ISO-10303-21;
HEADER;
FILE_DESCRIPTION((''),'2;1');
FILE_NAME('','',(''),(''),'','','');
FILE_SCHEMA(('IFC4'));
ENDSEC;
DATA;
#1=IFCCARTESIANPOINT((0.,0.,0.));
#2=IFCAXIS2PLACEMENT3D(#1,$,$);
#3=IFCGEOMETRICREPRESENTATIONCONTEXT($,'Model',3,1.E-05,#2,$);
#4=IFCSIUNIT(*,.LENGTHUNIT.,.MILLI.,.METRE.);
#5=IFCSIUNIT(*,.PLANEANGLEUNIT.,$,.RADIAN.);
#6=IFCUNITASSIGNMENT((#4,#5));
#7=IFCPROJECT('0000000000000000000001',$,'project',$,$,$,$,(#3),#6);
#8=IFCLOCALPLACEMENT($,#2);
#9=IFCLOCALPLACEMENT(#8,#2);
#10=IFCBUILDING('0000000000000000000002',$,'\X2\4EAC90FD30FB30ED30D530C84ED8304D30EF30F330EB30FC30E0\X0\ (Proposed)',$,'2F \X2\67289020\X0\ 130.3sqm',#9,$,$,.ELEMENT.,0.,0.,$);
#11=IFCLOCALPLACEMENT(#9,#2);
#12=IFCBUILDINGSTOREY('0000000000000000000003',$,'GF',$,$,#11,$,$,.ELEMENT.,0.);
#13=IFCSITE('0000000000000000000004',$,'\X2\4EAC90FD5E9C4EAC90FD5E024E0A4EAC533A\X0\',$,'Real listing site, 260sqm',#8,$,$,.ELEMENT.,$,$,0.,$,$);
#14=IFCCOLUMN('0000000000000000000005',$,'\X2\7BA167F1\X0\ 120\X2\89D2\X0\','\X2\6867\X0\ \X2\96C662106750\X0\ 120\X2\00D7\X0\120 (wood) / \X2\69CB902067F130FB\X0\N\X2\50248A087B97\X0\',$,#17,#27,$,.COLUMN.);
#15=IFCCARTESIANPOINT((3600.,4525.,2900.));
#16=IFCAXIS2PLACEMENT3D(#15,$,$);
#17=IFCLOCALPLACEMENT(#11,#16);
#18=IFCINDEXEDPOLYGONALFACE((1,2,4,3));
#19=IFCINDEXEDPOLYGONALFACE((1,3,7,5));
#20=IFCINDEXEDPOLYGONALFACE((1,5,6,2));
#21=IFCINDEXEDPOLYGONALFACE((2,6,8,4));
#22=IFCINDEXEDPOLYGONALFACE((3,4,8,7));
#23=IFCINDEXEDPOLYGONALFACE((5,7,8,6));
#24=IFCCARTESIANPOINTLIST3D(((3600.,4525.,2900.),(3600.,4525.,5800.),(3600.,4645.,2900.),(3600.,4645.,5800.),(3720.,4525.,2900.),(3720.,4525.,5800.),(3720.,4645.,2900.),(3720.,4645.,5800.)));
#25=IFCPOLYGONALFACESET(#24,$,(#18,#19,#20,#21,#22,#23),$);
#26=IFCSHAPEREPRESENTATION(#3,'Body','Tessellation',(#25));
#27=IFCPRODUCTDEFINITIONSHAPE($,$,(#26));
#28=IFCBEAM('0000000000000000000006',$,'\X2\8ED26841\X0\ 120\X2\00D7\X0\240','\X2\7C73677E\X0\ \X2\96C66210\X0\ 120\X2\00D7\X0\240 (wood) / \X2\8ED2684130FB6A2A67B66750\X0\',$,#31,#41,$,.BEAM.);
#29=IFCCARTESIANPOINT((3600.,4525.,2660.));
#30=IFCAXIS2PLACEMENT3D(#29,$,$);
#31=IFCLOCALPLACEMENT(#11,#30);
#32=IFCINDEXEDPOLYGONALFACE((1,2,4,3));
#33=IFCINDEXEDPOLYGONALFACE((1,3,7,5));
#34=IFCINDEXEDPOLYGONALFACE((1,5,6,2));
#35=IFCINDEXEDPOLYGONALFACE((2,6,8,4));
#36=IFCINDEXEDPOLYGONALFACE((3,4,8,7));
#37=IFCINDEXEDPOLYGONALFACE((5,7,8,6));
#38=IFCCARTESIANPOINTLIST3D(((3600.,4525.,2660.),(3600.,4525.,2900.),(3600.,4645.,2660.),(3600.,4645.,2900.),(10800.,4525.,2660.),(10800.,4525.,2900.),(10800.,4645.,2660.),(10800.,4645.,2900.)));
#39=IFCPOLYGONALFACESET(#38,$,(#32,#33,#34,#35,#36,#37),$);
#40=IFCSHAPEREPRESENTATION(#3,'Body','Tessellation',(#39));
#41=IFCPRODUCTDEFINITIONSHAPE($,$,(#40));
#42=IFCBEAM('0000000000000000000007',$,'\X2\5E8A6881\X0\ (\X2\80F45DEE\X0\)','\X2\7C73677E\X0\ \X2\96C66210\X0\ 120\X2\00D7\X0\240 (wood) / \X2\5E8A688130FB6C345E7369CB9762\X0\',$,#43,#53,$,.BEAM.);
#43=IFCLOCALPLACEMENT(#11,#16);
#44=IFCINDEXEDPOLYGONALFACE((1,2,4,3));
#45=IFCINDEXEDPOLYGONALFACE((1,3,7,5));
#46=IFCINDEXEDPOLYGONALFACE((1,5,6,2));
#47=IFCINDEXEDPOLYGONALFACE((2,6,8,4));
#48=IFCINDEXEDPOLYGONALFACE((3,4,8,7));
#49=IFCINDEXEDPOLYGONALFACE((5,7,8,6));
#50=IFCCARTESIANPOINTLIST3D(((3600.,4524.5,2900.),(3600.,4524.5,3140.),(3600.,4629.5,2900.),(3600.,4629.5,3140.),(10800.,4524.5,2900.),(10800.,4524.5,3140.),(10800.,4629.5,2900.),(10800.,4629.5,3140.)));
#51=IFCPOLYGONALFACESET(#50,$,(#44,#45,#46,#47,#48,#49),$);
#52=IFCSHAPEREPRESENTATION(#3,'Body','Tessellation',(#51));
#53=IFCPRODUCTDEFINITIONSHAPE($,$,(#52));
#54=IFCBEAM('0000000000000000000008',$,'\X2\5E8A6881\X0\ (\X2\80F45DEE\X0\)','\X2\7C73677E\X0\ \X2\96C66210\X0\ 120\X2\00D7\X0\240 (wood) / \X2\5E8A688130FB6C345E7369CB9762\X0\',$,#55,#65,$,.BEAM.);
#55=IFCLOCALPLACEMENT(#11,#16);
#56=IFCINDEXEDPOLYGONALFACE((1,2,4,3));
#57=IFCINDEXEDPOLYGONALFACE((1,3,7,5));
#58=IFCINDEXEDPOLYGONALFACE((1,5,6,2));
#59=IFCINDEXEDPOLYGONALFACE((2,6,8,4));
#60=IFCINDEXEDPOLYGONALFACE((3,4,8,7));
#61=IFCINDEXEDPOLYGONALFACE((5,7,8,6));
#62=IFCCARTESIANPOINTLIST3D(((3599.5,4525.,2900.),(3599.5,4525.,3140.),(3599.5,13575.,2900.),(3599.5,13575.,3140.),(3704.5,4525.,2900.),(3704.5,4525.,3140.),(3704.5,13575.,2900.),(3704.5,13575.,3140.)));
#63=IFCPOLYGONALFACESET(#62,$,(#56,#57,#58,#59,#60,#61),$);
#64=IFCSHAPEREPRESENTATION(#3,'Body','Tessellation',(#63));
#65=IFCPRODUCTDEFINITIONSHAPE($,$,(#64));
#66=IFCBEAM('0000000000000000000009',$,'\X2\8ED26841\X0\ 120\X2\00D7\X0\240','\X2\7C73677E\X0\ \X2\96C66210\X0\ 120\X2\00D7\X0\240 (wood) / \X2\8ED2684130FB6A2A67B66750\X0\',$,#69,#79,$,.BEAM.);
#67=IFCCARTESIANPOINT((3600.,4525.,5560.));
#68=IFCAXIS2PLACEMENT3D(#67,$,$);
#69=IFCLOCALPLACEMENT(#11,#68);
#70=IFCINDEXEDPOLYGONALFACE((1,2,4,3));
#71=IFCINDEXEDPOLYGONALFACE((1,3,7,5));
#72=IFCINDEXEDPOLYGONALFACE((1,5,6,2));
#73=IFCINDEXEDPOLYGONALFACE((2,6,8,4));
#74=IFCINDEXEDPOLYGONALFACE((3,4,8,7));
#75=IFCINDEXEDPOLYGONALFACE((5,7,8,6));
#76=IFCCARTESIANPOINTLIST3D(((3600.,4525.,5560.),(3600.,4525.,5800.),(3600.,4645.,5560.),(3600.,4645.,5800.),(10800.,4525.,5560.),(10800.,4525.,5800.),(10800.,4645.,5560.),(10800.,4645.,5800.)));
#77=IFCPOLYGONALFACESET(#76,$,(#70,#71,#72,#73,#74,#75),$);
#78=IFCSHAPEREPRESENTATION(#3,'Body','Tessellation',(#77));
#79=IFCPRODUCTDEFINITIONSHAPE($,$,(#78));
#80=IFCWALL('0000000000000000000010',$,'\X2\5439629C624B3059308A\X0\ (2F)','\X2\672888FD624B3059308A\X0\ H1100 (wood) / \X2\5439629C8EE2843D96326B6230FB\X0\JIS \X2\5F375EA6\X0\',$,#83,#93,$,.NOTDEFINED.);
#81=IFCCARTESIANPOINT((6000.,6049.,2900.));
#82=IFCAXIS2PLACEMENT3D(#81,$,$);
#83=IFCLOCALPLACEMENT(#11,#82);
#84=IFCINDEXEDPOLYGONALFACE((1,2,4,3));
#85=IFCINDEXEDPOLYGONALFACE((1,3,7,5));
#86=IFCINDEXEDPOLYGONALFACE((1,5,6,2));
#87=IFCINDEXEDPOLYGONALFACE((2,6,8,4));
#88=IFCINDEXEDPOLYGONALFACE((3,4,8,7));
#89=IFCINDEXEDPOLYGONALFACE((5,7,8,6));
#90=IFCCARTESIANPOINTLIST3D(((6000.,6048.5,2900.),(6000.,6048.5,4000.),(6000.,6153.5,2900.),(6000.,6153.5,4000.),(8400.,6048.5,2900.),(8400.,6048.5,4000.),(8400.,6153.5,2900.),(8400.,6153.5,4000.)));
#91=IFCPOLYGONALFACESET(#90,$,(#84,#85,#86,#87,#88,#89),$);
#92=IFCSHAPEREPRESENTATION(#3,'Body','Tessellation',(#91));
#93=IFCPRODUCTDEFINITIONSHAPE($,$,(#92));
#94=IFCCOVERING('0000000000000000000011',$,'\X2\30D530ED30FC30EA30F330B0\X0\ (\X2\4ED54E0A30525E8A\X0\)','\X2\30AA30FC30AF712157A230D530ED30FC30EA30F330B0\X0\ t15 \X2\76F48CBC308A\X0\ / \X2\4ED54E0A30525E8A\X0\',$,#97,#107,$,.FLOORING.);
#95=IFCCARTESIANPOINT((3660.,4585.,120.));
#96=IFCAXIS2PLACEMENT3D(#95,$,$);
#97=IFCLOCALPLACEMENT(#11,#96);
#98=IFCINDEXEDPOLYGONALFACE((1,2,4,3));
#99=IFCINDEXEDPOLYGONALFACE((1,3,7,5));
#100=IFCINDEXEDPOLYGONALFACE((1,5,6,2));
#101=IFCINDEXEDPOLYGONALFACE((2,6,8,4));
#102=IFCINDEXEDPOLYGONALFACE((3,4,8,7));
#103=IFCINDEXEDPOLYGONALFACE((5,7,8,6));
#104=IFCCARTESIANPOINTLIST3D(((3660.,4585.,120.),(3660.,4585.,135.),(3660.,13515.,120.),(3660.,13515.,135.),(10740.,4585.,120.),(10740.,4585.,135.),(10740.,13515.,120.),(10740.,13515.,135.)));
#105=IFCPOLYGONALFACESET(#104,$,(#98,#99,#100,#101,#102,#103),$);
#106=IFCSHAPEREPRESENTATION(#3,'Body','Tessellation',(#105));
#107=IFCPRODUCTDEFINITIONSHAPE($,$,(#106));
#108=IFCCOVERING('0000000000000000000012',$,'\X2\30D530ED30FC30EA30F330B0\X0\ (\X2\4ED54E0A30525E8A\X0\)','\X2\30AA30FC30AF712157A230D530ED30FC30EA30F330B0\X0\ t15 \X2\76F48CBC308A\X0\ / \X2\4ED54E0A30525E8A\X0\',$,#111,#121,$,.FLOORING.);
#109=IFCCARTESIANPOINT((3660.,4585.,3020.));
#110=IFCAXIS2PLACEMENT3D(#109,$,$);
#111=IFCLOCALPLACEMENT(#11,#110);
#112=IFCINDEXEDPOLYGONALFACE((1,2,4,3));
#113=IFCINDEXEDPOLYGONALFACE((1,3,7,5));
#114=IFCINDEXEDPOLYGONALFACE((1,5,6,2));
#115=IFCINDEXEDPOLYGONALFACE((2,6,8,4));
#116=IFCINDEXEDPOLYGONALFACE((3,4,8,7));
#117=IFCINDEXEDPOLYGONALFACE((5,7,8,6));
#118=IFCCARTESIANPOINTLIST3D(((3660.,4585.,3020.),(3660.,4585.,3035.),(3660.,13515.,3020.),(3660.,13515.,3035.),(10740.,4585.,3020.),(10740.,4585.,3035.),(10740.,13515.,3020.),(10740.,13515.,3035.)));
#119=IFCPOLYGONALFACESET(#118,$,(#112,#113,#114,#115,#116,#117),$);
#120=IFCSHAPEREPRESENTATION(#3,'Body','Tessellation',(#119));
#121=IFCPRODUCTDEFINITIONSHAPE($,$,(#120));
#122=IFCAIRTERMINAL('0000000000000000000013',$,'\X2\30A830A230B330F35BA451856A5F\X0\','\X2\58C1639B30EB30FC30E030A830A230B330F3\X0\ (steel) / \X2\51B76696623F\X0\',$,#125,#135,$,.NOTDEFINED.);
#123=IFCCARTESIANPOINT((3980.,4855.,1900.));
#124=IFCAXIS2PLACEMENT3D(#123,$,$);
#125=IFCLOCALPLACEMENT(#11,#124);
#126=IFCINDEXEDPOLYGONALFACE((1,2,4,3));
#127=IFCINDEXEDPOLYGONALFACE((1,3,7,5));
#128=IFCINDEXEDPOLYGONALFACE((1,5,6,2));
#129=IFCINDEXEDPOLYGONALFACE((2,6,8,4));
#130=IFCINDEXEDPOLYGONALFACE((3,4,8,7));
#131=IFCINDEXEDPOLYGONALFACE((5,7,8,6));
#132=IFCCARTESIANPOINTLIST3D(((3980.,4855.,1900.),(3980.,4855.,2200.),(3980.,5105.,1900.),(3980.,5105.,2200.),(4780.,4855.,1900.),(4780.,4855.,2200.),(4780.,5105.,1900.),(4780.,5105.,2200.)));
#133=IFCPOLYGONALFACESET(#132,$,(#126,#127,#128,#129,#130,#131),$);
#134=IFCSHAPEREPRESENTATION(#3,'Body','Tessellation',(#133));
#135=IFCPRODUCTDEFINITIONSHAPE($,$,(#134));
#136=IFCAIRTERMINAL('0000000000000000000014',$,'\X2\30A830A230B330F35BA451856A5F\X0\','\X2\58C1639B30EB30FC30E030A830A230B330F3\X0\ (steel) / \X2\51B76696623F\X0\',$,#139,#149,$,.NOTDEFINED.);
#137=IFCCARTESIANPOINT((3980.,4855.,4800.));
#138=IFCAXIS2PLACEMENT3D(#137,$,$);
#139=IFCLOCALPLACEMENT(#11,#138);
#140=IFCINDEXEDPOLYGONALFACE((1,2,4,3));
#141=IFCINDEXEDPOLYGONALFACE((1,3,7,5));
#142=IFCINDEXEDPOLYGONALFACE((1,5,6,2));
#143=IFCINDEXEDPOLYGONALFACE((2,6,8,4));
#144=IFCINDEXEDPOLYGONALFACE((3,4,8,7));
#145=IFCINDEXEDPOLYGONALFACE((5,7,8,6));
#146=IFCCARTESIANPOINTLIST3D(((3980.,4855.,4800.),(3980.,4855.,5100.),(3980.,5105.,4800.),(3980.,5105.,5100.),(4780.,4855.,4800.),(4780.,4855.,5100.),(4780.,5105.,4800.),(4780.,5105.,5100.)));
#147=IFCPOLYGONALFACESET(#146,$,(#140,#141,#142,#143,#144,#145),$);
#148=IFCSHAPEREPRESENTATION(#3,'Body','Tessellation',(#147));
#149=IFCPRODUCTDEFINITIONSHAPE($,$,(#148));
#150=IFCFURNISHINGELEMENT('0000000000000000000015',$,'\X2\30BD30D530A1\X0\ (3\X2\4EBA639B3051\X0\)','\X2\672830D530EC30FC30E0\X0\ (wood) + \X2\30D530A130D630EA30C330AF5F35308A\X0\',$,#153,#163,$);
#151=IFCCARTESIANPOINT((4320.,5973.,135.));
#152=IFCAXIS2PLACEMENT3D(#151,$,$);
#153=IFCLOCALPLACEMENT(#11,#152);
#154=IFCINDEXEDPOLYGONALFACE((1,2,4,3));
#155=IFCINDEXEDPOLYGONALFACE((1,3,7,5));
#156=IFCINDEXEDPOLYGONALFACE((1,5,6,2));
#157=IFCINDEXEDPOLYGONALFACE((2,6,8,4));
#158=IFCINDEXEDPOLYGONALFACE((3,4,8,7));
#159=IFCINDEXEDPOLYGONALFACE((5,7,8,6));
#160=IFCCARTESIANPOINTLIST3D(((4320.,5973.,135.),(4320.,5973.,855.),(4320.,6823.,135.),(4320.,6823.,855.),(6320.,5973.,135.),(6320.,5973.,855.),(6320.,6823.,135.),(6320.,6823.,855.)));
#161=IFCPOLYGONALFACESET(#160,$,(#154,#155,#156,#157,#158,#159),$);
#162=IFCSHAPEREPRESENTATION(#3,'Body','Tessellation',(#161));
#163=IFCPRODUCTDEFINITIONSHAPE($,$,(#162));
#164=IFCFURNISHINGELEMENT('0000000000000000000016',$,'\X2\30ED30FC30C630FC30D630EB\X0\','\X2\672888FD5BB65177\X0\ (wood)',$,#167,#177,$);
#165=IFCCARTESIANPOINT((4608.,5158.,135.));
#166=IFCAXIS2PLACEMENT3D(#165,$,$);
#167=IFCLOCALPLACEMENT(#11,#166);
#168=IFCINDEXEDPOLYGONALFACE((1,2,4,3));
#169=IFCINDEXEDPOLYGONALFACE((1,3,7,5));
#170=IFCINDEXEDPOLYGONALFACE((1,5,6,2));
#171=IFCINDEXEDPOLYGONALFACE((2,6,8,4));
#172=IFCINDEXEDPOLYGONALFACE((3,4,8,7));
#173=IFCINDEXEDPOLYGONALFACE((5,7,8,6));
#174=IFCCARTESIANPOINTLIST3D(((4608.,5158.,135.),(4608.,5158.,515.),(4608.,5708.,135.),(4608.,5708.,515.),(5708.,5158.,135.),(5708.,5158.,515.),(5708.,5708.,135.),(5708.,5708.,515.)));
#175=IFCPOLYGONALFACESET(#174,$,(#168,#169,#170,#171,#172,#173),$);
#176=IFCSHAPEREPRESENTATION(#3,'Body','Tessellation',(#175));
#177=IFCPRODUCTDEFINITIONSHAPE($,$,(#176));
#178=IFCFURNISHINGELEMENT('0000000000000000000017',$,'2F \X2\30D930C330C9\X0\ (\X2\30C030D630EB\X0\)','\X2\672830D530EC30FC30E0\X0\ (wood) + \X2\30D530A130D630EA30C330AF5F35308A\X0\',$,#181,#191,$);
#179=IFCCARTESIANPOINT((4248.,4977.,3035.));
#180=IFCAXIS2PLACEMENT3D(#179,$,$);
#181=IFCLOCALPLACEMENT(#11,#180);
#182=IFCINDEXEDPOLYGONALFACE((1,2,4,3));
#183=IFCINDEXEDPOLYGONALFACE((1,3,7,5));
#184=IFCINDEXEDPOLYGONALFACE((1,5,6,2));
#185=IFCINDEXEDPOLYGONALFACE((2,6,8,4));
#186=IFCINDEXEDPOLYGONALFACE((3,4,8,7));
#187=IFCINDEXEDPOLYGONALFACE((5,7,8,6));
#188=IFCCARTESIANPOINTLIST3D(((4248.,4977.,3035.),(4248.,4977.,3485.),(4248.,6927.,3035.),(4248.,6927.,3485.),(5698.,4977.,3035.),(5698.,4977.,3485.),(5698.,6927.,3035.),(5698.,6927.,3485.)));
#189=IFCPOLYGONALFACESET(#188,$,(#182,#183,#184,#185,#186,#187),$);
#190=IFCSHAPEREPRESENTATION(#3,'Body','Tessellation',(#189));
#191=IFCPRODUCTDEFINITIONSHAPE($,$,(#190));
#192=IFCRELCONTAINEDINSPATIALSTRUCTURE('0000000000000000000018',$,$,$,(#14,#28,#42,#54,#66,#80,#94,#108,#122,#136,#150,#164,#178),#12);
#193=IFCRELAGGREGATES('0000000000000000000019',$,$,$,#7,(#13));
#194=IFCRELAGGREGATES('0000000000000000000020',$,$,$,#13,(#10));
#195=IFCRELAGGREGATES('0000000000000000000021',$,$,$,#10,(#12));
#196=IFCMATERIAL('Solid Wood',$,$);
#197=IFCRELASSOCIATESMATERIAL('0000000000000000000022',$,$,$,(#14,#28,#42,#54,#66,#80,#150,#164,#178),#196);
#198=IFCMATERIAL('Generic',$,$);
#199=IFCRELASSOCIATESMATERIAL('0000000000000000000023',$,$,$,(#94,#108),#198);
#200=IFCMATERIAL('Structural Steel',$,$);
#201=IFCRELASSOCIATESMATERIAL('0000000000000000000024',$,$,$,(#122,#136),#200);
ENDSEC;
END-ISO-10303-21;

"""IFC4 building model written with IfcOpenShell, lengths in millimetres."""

from ifc_helpers import new_model, si_unit, frame, frame_2d, origin, place, context, project, spatial, rectangle, extrude, material, element, save


model = new_model("IFC4")

# Units and contexts
model_context = context("Model", 3, precision=1e-05, world=origin())
ifc_project = project(units=[si_unit("LENGTHUNIT", "METRE", prefix="MILLI"), si_unit("PLANEANGLEUNIT", "RADIAN")], contexts=[model_context])

# Site, building, storey
site_placement = place(None, origin())
site = spatial("IfcSite", under=ifc_project, at=site_placement, Name="京都府京都市上京区", ObjectType="Real listing site, 260sqm", CompositionType="ELEMENT", RefElevation=0.0)
building_placement = place(site_placement, origin())
building = spatial("IfcBuilding", under=site, at=building_placement, Name="京都・ロフト付きワンルーム (Proposed)", ObjectType="2F 木造 130.3sqm", CompositionType="ELEMENT", ElevationOfRefHeight=0.0, ElevationOfTerrain=0.0)
storey_placement = place(building_placement, origin())
storey = spatial("IfcBuildingStorey", under=building, at=storey_placement, Name="GF", CompositionType="ELEMENT", Elevation=0.0)

# Column
ifc_material_1 = material(Name="Solid Wood")
column_1_placement = place(storey_placement, frame((3600.0, 4525.0, 2900.0)))
element("IfcColumn", 1, at=column_1_placement, inside=storey, material=ifc_material_1, Name="管柱 120角", Description="桧 集成材 120×120 (wood) / 構造柱・N値計算", PredefinedType="COLUMN", context=model_context, shape_type="SweptSolid", body=[
    extrude(rectangle(XDim=120.0, YDim=120.0, at=frame_2d((60.0, 60.0))), frame((3600.0, 4525.0, 2900.0)), (0.0, 0.0, 1.0), 2900.0),
])

# Beams
beam_1_placement = place(storey_placement, frame((3600.0, 4525.0, 2660.0)))
element("IfcBeam", 2, at=beam_1_placement, inside=storey, material=ifc_material_1, Name="軒桁 120×240", Description="米松 集成 120×240 (wood) / 軒桁・横架材", PredefinedType="BEAM", context=model_context, shape_type="SweptSolid", body=[
    extrude(rectangle(XDim=7200.0, YDim=120.0, at=frame_2d((3600.0, 60.0))), frame((3600.0, 4525.0, 2660.0)), (0.0, 0.0, 1.0), 240.0),
])
beam_2_placement = place(storey_placement, frame((3600.0, 4525.0, 2900.0)))
element("IfcBeam", 3, at=beam_2_placement, inside=storey, material=ifc_material_1, Name="床梁 (胴差)", Description="米松 集成 120×240 (wood) / 床梁・水平構面", PredefinedType="BEAM", context=model_context, shape_type="SweptSolid", body=[
    extrude(rectangle(XDim=7200.0, YDim=105.0, at=frame_2d((3600.0, 52.0))), frame((3600.0, 4525.0, 2900.0)), (0.0, 0.0, 1.0), 240.0),
])
beam_3_placement = place(storey_placement, frame((3600.0, 4525.0, 2900.0)))
element("IfcBeam", 4, at=beam_3_placement, inside=storey, material=ifc_material_1, Name="床梁 (胴差)", Description="米松 集成 120×240 (wood) / 床梁・水平構面", PredefinedType="BEAM", context=model_context, shape_type="SweptSolid", body=[
    extrude(rectangle(XDim=105.0, YDim=9050.0, at=frame_2d((52.0, 4525.0))), frame((3600.0, 4525.0, 2900.0)), (0.0, 0.0, 1.0), 240.0),
])
beam_4_placement = place(storey_placement, frame((3600.0, 4525.0, 5560.0)))
element("IfcBeam", 5, at=beam_4_placement, inside=storey, material=ifc_material_1, Name="軒桁 120×240", Description="米松 集成 120×240 (wood) / 軒桁・横架材", PredefinedType="BEAM", context=model_context, shape_type="SweptSolid", body=[
    extrude(rectangle(XDim=7200.0, YDim=120.0, at=frame_2d((3600.0, 60.0))), frame((3600.0, 4525.0, 5560.0)), (0.0, 0.0, 1.0), 240.0),
])

# Wall
wall_placement = place(storey_placement, frame((6000.0, 6049.0, 2900.0)))
element("IfcWall", 6, at=wall_placement, inside=storey, material=ifc_material_1, Name="吹抜手すり (2F)", Description="木製手すり H1100 (wood) / 吹抜転落防止・JIS 強度", PredefinedType="NOTDEFINED", context=model_context, shape_type="SweptSolid", body=[
    extrude(rectangle(XDim=2400.0, YDim=105.0, at=frame_2d((1200.0, 52.0))), frame((6000.0, 6049.0, 2900.0)), (0.0, 0.0, 1.0), 1100.0),
])

# Coverings
ifc_material_2 = material(Name="Generic")
covering_1_placement = place(storey_placement, frame((3660.0, 4585.0, 120.0)))
element("IfcCovering", 7, at=covering_1_placement, inside=storey, material=ifc_material_2, Name="フローリング (仕上げ床)", Description="オーク無垢フローリング t15 直貼り / 仕上げ床", PredefinedType="FLOORING", context=model_context, shape_type="SweptSolid", body=[
    extrude(rectangle(XDim=7080.0, YDim=8930.0, at=frame_2d((3540.0, 4465.0))), frame((3660.0, 4585.0, 120.0)), (0.0, 0.0, 1.0), 15.0),
])
covering_2_placement = place(storey_placement, frame((3660.0, 4585.0, 3020.0)))
element("IfcCovering", 8, at=covering_2_placement, inside=storey, material=ifc_material_2, Name="フローリング (仕上げ床)", Description="オーク無垢フローリング t15 直貼り / 仕上げ床", PredefinedType="FLOORING", context=model_context, shape_type="SweptSolid", body=[
    extrude(rectangle(XDim=7080.0, YDim=8930.0, at=frame_2d((3540.0, 4465.0))), frame((3660.0, 4585.0, 3020.0)), (0.0, 0.0, 1.0), 15.0),
])

# Air terminals
ifc_material_3 = material(Name="Structural Steel")
air_terminal_1_placement = place(storey_placement, frame((3980.0, 4855.0, 1900.0)))
element("IfcAirTerminal", 9, at=air_terminal_1_placement, inside=storey, material=ifc_material_3, Name="エアコン室内機", Description="壁掛ルームエアコン (steel) / 冷暖房", PredefinedType="NOTDEFINED", context=model_context, shape_type="SweptSolid", body=[
    extrude(rectangle(XDim=800.0, YDim=250.0, at=frame_2d((400.0, 125.0))), frame((3980.0, 4855.0, 1900.0)), (0.0, 0.0, 1.0), 300.0),
])
air_terminal_2_placement = place(storey_placement, frame((3980.0, 4855.0, 4800.0)))
element("IfcAirTerminal", 10, at=air_terminal_2_placement, inside=storey, material=ifc_material_3, Name="エアコン室内機", Description="壁掛ルームエアコン (steel) / 冷暖房", PredefinedType="NOTDEFINED", context=model_context, shape_type="SweptSolid", body=[
    extrude(rectangle(XDim=800.0, YDim=250.0, at=frame_2d((400.0, 125.0))), frame((3980.0, 4855.0, 4800.0)), (0.0, 0.0, 1.0), 300.0),
])

# Furnishing elements
furnishing_1_placement = place(storey_placement, frame((4320.0, 5973.0, 135.0)))
element("IfcFurnishingElement", 11, at=furnishing_1_placement, inside=storey, material=ifc_material_1, Name="ソファ (3人掛け)", Description="木フレーム (wood) + ファブリック張り", context=model_context, shape_type="SweptSolid", body=[
    extrude(rectangle(XDim=2000.0, YDim=850.0, at=frame_2d((1000.0, 425.0))), frame((4320.0, 5973.0, 135.0)), (0.0, 0.0, 1.0), 720.0),
])
furnishing_2_placement = place(storey_placement, frame((4608.0, 5158.0, 135.0)))
element("IfcFurnishingElement", 12, at=furnishing_2_placement, inside=storey, material=ifc_material_1, Name="ローテーブル", Description="木製家具 (wood)", context=model_context, shape_type="SweptSolid", body=[
    extrude(rectangle(XDim=1100.0, YDim=550.0, at=frame_2d((550.0, 275.0))), frame((4608.0, 5158.0, 135.0)), (0.0, 0.0, 1.0), 380.0),
])
furnishing_3_placement = place(storey_placement, frame((4248.0, 4977.0, 3035.0)))
element("IfcFurnishingElement", 13, at=furnishing_3_placement, inside=storey, material=ifc_material_1, Name="2F ベッド (ダブル)", Description="木フレーム (wood) + ファブリック張り", context=model_context, shape_type="SweptSolid", body=[
    extrude(rectangle(XDim=1450.0, YDim=1950.0, at=frame_2d((725.0, 975.0))), frame((4248.0, 4977.0, 3035.0)), (0.0, 0.0, 1.0), 450.0),
])

save(model, "model.ifc")
